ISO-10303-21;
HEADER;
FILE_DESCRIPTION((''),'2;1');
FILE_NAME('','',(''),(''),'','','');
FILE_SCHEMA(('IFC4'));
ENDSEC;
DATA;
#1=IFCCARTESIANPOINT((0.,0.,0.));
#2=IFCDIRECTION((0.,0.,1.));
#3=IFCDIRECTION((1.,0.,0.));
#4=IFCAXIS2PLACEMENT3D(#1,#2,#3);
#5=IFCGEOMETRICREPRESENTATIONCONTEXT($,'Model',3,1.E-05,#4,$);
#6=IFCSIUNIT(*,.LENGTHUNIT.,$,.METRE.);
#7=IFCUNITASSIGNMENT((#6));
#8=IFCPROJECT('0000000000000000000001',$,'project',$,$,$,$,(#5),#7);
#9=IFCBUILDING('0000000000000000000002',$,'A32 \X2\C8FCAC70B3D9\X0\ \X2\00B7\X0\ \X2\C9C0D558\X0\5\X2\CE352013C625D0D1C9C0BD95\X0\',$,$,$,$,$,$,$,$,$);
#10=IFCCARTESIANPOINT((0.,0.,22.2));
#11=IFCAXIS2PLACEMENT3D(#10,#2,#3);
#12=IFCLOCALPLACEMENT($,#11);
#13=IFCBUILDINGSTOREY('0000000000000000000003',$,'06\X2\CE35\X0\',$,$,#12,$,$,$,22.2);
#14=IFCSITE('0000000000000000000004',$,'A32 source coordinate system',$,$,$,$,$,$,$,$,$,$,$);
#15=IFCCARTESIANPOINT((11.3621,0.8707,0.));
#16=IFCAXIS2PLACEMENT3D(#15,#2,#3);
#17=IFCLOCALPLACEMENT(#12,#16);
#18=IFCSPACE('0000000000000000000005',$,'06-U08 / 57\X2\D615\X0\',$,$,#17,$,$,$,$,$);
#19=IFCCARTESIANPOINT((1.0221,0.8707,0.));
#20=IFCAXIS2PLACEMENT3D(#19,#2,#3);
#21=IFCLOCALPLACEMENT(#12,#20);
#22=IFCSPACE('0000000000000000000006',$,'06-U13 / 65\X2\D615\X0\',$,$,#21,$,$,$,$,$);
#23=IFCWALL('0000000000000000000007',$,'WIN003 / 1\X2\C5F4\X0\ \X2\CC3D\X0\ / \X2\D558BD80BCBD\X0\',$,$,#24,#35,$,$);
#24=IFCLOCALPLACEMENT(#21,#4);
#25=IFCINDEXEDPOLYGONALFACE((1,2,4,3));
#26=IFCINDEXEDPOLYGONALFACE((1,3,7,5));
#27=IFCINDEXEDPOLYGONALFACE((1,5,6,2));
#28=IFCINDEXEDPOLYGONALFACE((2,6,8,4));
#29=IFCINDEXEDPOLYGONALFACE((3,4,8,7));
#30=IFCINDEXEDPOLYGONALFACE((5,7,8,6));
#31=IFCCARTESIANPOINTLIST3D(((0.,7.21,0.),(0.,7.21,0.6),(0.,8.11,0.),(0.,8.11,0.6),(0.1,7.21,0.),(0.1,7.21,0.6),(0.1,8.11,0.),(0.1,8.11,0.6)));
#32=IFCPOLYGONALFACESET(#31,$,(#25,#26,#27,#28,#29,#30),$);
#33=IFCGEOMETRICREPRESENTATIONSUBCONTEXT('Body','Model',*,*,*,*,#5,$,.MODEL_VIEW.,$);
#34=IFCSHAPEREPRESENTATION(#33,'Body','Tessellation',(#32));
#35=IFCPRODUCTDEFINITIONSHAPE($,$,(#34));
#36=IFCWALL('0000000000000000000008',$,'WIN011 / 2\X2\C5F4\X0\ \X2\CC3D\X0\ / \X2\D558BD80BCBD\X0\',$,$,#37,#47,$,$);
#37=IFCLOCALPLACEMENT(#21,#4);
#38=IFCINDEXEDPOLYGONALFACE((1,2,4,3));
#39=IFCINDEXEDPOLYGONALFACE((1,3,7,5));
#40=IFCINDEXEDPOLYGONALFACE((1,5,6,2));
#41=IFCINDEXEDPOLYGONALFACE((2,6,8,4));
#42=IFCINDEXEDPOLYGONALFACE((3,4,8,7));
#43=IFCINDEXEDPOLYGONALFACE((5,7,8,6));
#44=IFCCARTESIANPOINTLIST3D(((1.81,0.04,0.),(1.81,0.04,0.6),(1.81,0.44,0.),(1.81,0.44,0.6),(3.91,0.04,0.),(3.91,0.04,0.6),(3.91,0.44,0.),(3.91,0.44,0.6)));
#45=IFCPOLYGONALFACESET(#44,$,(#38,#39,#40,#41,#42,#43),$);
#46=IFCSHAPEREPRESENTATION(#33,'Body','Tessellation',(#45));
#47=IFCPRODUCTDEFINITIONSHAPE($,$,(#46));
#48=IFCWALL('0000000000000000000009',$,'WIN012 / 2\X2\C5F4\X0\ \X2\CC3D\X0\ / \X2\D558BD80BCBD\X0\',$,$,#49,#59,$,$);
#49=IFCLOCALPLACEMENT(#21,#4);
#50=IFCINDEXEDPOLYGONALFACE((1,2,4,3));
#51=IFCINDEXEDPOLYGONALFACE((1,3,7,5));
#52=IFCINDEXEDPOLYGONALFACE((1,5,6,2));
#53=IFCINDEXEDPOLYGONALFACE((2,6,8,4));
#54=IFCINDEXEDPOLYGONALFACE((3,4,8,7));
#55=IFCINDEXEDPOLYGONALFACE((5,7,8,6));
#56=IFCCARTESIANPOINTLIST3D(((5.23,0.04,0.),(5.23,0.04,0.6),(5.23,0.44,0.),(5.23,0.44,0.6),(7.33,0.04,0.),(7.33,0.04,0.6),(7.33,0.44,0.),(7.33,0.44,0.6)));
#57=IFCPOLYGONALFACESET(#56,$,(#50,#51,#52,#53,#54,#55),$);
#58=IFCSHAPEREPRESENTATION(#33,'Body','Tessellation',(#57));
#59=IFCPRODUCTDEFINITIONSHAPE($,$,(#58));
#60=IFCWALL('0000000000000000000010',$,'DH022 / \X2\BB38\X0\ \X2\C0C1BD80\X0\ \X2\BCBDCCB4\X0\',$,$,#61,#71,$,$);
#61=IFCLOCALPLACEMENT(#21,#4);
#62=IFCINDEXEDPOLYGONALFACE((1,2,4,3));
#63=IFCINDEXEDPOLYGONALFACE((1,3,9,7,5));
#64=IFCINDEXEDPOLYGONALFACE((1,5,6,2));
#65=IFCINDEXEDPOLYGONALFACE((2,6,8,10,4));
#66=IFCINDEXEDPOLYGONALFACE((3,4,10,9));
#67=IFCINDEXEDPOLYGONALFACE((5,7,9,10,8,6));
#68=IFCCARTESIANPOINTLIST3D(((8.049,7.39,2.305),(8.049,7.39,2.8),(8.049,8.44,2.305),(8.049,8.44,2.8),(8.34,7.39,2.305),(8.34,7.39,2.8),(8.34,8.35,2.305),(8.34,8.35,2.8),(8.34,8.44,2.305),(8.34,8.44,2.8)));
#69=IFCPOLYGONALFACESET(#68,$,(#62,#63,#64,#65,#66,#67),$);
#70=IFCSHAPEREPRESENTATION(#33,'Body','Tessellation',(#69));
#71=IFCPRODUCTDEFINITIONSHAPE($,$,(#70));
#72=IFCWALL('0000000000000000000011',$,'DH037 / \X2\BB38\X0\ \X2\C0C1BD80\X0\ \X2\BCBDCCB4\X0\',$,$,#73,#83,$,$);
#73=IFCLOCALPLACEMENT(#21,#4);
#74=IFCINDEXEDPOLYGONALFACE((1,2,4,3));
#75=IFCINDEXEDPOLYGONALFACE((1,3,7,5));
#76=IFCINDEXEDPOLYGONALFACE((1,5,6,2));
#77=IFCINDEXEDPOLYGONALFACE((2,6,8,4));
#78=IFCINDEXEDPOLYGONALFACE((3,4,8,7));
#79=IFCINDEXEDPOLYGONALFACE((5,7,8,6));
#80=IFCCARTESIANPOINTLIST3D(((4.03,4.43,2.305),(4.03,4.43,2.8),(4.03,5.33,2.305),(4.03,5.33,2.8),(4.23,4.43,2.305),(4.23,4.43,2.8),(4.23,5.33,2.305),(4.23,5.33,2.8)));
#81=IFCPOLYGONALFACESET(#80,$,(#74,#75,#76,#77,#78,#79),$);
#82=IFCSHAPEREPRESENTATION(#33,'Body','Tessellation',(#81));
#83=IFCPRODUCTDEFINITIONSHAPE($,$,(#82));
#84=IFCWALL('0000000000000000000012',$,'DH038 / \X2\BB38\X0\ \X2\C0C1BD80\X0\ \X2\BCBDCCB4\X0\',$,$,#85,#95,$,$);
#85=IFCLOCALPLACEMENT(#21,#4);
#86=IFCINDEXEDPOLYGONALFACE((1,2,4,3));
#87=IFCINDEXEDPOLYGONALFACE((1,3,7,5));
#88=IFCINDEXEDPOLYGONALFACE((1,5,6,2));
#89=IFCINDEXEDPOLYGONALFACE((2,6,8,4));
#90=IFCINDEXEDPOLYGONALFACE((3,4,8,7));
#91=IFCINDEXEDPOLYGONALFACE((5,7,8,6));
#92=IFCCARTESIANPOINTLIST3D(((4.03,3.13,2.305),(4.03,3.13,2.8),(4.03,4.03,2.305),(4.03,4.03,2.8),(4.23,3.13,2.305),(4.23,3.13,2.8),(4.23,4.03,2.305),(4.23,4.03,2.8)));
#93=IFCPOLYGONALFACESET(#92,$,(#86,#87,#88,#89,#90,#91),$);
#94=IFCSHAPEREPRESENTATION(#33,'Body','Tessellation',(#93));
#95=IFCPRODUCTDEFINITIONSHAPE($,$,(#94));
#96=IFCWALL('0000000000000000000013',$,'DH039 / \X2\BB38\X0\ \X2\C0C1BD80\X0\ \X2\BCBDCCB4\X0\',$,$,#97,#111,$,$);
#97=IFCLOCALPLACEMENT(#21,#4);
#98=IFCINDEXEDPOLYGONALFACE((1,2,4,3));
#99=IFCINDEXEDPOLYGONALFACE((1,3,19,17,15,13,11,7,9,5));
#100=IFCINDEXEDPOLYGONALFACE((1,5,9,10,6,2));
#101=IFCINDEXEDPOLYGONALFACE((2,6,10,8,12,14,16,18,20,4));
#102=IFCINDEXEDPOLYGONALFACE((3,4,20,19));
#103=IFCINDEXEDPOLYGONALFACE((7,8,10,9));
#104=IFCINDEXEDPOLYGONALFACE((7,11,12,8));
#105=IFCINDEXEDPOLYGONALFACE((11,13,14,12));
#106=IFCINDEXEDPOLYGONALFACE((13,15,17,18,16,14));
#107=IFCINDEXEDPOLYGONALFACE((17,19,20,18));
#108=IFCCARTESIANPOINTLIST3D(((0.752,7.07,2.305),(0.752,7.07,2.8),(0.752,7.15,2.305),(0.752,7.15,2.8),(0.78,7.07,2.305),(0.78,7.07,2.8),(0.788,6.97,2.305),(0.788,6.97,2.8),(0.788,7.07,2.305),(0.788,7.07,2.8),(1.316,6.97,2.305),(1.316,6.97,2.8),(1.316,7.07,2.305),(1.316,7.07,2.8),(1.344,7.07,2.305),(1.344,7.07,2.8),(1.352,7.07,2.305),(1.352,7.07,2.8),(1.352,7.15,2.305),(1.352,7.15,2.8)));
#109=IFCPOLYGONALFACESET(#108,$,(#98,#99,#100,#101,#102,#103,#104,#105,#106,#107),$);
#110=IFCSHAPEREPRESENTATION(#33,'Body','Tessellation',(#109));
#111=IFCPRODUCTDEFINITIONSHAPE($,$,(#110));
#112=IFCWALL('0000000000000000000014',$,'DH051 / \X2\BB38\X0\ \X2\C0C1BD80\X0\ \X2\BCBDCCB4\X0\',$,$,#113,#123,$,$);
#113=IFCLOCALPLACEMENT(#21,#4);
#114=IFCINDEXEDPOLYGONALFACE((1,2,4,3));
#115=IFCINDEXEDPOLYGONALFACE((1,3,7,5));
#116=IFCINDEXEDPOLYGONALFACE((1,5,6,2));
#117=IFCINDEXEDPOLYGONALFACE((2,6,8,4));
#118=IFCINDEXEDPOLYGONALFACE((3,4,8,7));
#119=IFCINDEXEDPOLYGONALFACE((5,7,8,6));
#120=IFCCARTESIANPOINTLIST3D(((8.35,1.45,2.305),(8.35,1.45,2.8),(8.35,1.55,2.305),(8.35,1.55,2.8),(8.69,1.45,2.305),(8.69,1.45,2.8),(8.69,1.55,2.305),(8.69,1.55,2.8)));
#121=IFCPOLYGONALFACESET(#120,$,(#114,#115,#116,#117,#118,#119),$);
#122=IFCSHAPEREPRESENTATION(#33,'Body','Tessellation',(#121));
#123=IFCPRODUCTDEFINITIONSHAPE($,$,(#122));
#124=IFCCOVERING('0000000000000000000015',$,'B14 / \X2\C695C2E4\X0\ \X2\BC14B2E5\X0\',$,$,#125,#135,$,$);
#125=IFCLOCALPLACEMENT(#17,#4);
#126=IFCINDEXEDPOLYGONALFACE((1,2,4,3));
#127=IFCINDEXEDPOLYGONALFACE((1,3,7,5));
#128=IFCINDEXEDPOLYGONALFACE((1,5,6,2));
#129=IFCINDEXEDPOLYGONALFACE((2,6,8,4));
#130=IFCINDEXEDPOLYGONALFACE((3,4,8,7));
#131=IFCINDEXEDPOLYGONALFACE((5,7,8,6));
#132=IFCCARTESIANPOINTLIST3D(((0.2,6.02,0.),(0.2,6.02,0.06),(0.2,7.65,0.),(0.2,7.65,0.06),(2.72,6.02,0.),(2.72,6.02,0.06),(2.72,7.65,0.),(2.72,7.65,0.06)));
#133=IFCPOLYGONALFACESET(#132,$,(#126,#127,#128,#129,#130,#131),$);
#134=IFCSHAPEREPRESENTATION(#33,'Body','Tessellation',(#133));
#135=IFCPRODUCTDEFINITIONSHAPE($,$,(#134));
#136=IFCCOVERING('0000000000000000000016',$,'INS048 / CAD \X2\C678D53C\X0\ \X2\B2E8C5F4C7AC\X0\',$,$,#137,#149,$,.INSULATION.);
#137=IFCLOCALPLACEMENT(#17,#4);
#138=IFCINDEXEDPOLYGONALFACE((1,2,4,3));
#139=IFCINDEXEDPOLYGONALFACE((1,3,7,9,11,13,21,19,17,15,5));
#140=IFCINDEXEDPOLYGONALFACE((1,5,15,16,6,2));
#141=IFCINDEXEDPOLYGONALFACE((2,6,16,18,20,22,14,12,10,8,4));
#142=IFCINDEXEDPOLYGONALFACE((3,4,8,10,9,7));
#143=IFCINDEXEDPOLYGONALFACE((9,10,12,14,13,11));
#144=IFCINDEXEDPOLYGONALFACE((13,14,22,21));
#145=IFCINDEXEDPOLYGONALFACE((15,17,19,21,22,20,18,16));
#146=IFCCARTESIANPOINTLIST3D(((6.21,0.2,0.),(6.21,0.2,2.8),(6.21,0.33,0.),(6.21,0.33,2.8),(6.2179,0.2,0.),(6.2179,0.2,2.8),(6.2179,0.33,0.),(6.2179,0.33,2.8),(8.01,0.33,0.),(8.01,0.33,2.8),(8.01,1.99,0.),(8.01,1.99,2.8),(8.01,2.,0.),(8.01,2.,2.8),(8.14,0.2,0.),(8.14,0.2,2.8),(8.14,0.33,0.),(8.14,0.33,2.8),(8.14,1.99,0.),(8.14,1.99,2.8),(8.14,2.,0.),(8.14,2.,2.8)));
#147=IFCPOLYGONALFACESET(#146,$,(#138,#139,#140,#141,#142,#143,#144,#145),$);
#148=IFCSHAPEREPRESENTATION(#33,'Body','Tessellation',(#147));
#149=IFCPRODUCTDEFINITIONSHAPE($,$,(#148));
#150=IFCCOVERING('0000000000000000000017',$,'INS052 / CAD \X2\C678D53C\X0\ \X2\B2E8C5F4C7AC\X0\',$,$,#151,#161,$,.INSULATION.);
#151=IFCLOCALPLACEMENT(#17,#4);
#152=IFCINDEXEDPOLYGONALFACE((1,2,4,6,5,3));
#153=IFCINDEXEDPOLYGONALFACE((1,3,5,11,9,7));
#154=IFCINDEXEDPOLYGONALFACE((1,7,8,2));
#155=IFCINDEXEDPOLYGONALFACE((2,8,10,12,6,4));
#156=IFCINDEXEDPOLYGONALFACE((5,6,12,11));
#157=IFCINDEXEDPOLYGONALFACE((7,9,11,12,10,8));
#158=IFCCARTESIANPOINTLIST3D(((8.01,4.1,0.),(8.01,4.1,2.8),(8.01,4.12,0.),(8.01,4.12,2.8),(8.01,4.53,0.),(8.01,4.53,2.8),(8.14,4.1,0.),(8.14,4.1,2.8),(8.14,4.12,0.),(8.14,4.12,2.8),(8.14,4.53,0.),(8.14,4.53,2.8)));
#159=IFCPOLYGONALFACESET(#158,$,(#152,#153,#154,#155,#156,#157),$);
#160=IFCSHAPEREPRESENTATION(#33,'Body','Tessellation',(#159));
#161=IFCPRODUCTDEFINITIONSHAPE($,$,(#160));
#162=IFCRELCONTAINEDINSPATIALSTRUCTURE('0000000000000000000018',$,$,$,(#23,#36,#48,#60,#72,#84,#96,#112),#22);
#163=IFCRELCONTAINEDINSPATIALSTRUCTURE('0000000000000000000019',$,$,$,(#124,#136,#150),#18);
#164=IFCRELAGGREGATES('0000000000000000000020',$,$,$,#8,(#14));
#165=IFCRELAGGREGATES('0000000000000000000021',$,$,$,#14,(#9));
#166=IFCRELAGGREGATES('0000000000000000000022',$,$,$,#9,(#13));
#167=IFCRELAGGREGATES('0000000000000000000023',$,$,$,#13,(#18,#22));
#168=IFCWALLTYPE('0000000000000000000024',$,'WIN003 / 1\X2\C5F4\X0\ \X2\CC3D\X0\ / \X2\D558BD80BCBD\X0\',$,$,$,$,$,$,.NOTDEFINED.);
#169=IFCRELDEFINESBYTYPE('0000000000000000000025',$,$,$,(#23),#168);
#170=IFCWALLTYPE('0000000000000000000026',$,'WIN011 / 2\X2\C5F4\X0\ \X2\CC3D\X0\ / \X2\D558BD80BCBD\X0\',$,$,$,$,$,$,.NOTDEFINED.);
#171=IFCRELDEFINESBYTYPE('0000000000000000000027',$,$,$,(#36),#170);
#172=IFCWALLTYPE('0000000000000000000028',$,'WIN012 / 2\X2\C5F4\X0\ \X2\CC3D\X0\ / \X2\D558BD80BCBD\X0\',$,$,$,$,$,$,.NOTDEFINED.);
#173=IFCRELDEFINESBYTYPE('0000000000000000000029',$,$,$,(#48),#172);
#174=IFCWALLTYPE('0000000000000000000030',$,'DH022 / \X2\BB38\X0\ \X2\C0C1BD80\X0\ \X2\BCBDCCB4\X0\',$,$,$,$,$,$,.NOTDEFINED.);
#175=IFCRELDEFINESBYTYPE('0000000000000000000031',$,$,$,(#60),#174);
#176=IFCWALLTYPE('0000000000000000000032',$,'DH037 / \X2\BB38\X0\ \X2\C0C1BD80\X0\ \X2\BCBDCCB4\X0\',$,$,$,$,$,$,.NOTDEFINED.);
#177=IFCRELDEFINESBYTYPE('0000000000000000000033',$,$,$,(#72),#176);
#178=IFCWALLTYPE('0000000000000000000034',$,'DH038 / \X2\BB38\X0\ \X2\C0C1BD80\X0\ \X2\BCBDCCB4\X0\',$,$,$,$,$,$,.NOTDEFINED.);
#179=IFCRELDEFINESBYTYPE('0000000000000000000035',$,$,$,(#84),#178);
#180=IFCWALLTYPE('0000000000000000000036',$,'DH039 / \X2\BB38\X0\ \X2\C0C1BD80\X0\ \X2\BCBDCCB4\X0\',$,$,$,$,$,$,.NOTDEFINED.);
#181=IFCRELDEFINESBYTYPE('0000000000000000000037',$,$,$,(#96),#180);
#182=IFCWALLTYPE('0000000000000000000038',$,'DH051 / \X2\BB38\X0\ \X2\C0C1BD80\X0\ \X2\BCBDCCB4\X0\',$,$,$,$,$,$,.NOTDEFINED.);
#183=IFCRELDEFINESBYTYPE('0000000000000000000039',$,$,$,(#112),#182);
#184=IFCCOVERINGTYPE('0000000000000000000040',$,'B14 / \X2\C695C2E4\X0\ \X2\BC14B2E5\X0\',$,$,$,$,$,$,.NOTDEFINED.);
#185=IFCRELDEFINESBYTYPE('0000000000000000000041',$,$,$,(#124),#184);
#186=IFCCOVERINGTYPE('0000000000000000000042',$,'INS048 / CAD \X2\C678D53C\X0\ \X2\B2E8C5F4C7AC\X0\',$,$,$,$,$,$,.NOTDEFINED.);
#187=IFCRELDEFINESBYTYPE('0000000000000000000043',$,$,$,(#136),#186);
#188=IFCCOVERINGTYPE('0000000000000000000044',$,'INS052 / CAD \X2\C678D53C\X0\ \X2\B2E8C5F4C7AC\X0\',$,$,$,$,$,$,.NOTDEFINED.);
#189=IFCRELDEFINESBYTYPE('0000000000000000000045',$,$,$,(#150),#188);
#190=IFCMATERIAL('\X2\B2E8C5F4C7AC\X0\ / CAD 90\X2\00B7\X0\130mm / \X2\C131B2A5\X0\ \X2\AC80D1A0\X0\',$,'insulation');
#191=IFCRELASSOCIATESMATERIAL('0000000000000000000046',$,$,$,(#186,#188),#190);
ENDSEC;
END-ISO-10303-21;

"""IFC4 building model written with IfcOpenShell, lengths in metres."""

from ifc_helpers import new_model, si_unit, frame, origin, origin_with_axes, place, context, subcontext, project, spatial, polyline, outline, extrude, source, transform, mapped, material, type_object, type_shapes, element, save


model = new_model("IFC4")

# Units and contexts
model_context = context("Model", 3, precision=1e-05, world=origin_with_axes())
body_context = subcontext(model_context, "Body", "Model", "MODEL_VIEW")
ifc_project = project(units=[si_unit("LENGTHUNIT", "METRE")], contexts=[model_context])

# Site, building, storey, space
site = spatial("IfcSite", under=ifc_project, Name="A32 source coordinate system")
building = spatial("IfcBuilding", under=site, Name="A32 주거동 · 지하5층–옥탑지붕")
storey_placement = place(None, frame((0.0, 0.0, 22.2), z_axis=(0.0, 0.0, 1.0), x_axis=(1.0, 0.0, 0.0)))
storey = spatial("IfcBuildingStorey", under=building, at=storey_placement, Name="06층", Elevation=22.2)
space_1_placement = place(storey_placement, frame((11.3621, 0.8707, 0.0), z_axis=(0.0, 0.0, 1.0), x_axis=(1.0, 0.0, 0.0)))
space_1 = spatial("IfcSpace", under=storey, at=space_1_placement, Name="06-U08 / 57형")

# Shared definitions
space_2_placement = place(storey_placement, frame((1.0221, 0.8707, 0.0), z_axis=(0.0, 0.0, 1.0), x_axis=(1.0, 0.0, 0.0)))
space_2 = spatial("IfcSpace", under=storey, at=space_2_placement, Name="06-U13 / 65형")

# Walls
wall_type_1 = type_object("IfcWallType", Name="WIN003 / 1열 창 / 하부벽", PredefinedType="NOTDEFINED")
shared_shape_1 = source(origin(), body_context, "Body", "SweptSolid", [
    extrude(outline(polyline([(0.0, 8.11), (0.1, 8.11), (0.1, 7.21), (0.0, 7.21), (0.0, 8.11)])), origin(), (0.0, 0.0, 1.0), 0.6),
])
type_shapes(wall_type_1, [shared_shape_1])
wall_1_placement = place(space_2_placement, origin_with_axes())
element("IfcWall", 1, at=wall_1_placement, inside=space_2, type_object=wall_type_1, Name="WIN003 / 1열 창 / 하부벽", context=body_context, shape_type="MappedRepresentation", body=[
    mapped(shared_shape_1, transform((0.0, 0.0, 0.0), scale=1.0)),
])
wall_type_2 = type_object("IfcWallType", Name="WIN011 / 2열 창 / 하부벽", PredefinedType="NOTDEFINED")
shared_shape_2 = source(origin(), body_context, "Body", "SweptSolid", [
    extrude(outline(polyline([(1.81, 0.44), (3.91, 0.44), (3.91, 0.04), (1.81, 0.04), (1.81, 0.44)])), origin(), (0.0, 0.0, 1.0), 0.6),
])
type_shapes(wall_type_2, [shared_shape_2])
wall_2_placement = place(space_2_placement, origin_with_axes())
element("IfcWall", 2, at=wall_2_placement, inside=space_2, type_object=wall_type_2, Name="WIN011 / 2열 창 / 하부벽", context=body_context, shape_type="MappedRepresentation", body=[
    mapped(shared_shape_2, transform((0.0, 0.0, 0.0), scale=1.0)),
])
wall_type_3 = type_object("IfcWallType", Name="WIN012 / 2열 창 / 하부벽", PredefinedType="NOTDEFINED")
shared_shape_3 = source(origin(), body_context, "Body", "SweptSolid", [
    extrude(outline(polyline([(5.23, 0.44), (7.33, 0.44), (7.33, 0.04), (5.23, 0.04), (5.23, 0.44)])), origin(), (0.0, 0.0, 1.0), 0.6),
])
type_shapes(wall_type_3, [shared_shape_3])
wall_3_placement = place(space_2_placement, origin_with_axes())
element("IfcWall", 3, at=wall_3_placement, inside=space_2, type_object=wall_type_3, Name="WIN012 / 2열 창 / 하부벽", context=body_context, shape_type="MappedRepresentation", body=[
    mapped(shared_shape_3, transform((0.0, 0.0, 0.0), scale=1.0)),
])
wall_type_4 = type_object("IfcWallType", Name="DH022 / 문 상부 벽체", PredefinedType="NOTDEFINED")
shared_shape_4 = source(origin(), body_context, "Body", "SweptSolid", [
    extrude(outline(polyline([(8.049, 7.39), (8.049, 8.44), (8.34, 8.44), (8.34, 8.35), (8.34, 8.35), (8.34, 7.39), (8.049, 7.39)])), frame((0.0, 0.0, 2.305)), (0.0, 0.0, 1.0), 0.495),
])
type_shapes(wall_type_4, [shared_shape_4])
wall_4_placement = place(space_2_placement, origin_with_axes())
element("IfcWall", 4, at=wall_4_placement, inside=space_2, type_object=wall_type_4, Name="DH022 / 문 상부 벽체", context=body_context, shape_type="MappedRepresentation", body=[
    mapped(shared_shape_4, transform((0.0, 0.0, 0.0), scale=1.0)),
])
wall_type_5 = type_object("IfcWallType", Name="DH037 / 문 상부 벽체", PredefinedType="NOTDEFINED")
shared_shape_5 = source(origin(), body_context, "Body", "SweptSolid", [
    extrude(outline(polyline([(4.23, 5.33), (4.23, 4.43), (4.03, 4.43), (4.03, 5.33), (4.23, 5.33)])), frame((0.0, 0.0, 2.305)), (0.0, 0.0, 1.0), 0.495),
])
type_shapes(wall_type_5, [shared_shape_5])
wall_5_placement = place(space_2_placement, origin_with_axes())
element("IfcWall", 5, at=wall_5_placement, inside=space_2, type_object=wall_type_5, Name="DH037 / 문 상부 벽체", context=body_context, shape_type="MappedRepresentation", body=[
    mapped(shared_shape_5, transform((0.0, 0.0, 0.0), scale=1.0)),
])
wall_type_6 = type_object("IfcWallType", Name="DH038 / 문 상부 벽체", PredefinedType="NOTDEFINED")
shared_shape_6 = source(origin(), body_context, "Body", "SweptSolid", [
    extrude(outline(polyline([(4.23, 4.03), (4.23, 3.13), (4.03, 3.13), (4.03, 4.03), (4.23, 4.03)])), frame((0.0, 0.0, 2.305)), (0.0, 0.0, 1.0), 0.495),
])
type_shapes(wall_type_6, [shared_shape_6])
wall_6_placement = place(space_2_placement, origin_with_axes())
element("IfcWall", 6, at=wall_6_placement, inside=space_2, type_object=wall_type_6, Name="DH038 / 문 상부 벽체", context=body_context, shape_type="MappedRepresentation", body=[
    mapped(shared_shape_6, transform((0.0, 0.0, 0.0), scale=1.0)),
])
wall_type_7 = type_object("IfcWallType", Name="DH039 / 문 상부 벽체", PredefinedType="NOTDEFINED")
shared_shape_7 = source(origin(), body_context, "Body", "SweptSolid", [
    extrude(outline(polyline([(1.316, 7.07), (1.316, 6.97), (0.788, 6.97), (0.788, 7.07), (0.78, 7.07), (0.752, 7.07), (0.752, 7.15), (1.352, 7.15), (1.352, 7.07), (1.344, 7.07), (1.316, 7.07)])), frame((0.0, 0.0, 2.305)), (0.0, 0.0, 1.0), 0.495),
])
type_shapes(wall_type_7, [shared_shape_7])
wall_7_placement = place(space_2_placement, origin_with_axes())
element("IfcWall", 7, at=wall_7_placement, inside=space_2, type_object=wall_type_7, Name="DH039 / 문 상부 벽체", context=body_context, shape_type="MappedRepresentation", body=[
    mapped(shared_shape_7, transform((0.0, 0.0, 0.0), scale=1.0)),
])
wall_type_8 = type_object("IfcWallType", Name="DH051 / 문 상부 벽체", PredefinedType="NOTDEFINED")
shared_shape_8 = source(origin(), body_context, "Body", "SweptSolid", [
    extrude(outline(polyline([(8.69, 1.55), (8.69, 1.45), (8.35, 1.45), (8.35, 1.55), (8.69, 1.55)])), frame((0.0, 0.0, 2.305)), (0.0, 0.0, 1.0), 0.495),
])
type_shapes(wall_type_8, [shared_shape_8])
wall_8_placement = place(space_2_placement, origin_with_axes())
element("IfcWall", 8, at=wall_8_placement, inside=space_2, type_object=wall_type_8, Name="DH051 / 문 상부 벽체", context=body_context, shape_type="MappedRepresentation", body=[
    mapped(shared_shape_8, transform((0.0, 0.0, 0.0), scale=1.0)),
])

# Coverings
covering_type_1 = type_object("IfcCoveringType", Name="B14 / 욕실 바닥", PredefinedType="NOTDEFINED")
shared_shape_9 = source(origin(), body_context, "Body", "SweptSolid", [
    extrude(outline(polyline([(0.2, 7.65), (2.72, 7.65), (2.72, 6.02), (0.2, 6.02), (0.2, 7.65)])), origin(), (0.0, 0.0, 1.0), 0.06),
])
type_shapes(covering_type_1, [shared_shape_9])
covering_1_placement = place(space_1_placement, origin_with_axes())
element("IfcCovering", 9, at=covering_1_placement, inside=space_1, type_object=covering_type_1, Name="B14 / 욕실 바닥", context=body_context, shape_type="MappedRepresentation", body=[
    mapped(shared_shape_9, transform((0.0, 0.0, 0.0), scale=1.0)),
])
ifc_material = material(Name="단열재 / CAD 90·130mm / 성능 검토", Category="insulation")
covering_type_2 = type_object("IfcCoveringType", Name="INS048 / CAD 외피 단열재", PredefinedType="NOTDEFINED", material=ifc_material)
shared_shape_10 = source(origin(), body_context, "Body", "SweptSolid", [
    extrude(outline(polyline([(8.01, 1.99), (8.01, 2.0), (8.14, 2.0), (8.14, 1.99), (8.14, 0.33), (8.14, 0.2), (6.2179, 0.2), (6.21, 0.2), (6.21, 0.33), (6.2179, 0.33), (8.01, 0.33), (8.01, 1.99)])), origin(), (0.0, 0.0, 1.0), 2.8),
])
type_shapes(covering_type_2, [shared_shape_10])
covering_2_placement = place(space_1_placement, origin_with_axes())
element("IfcCovering", 10, at=covering_2_placement, inside=space_1, type_object=covering_type_2, Name="INS048 / CAD 외피 단열재", PredefinedType="INSULATION", context=body_context, shape_type="MappedRepresentation", body=[
    mapped(shared_shape_10, transform((0.0, 0.0, 0.0), scale=1.0)),
])
covering_type_3 = type_object("IfcCoveringType", Name="INS052 / CAD 외피 단열재", PredefinedType="NOTDEFINED", material=ifc_material)
shared_shape_11 = source(origin(), body_context, "Body", "SweptSolid", [
    extrude(outline(polyline([(8.14, 4.1), (8.01, 4.1), (8.01, 4.12), (8.01, 4.53), (8.14, 4.53), (8.14, 4.12), (8.14, 4.1)])), origin(), (0.0, 0.0, 1.0), 2.8),
])
type_shapes(covering_type_3, [shared_shape_11])
covering_3_placement = place(space_1_placement, origin_with_axes())
element("IfcCovering", 11, at=covering_3_placement, inside=space_1, type_object=covering_type_3, Name="INS052 / CAD 외피 단열재", PredefinedType="INSULATION", context=body_context, shape_type="MappedRepresentation", body=[
    mapped(shared_shape_11, transform((0.0, 0.0, 0.0), scale=1.0)),
])

save(model, "model.ifc")
